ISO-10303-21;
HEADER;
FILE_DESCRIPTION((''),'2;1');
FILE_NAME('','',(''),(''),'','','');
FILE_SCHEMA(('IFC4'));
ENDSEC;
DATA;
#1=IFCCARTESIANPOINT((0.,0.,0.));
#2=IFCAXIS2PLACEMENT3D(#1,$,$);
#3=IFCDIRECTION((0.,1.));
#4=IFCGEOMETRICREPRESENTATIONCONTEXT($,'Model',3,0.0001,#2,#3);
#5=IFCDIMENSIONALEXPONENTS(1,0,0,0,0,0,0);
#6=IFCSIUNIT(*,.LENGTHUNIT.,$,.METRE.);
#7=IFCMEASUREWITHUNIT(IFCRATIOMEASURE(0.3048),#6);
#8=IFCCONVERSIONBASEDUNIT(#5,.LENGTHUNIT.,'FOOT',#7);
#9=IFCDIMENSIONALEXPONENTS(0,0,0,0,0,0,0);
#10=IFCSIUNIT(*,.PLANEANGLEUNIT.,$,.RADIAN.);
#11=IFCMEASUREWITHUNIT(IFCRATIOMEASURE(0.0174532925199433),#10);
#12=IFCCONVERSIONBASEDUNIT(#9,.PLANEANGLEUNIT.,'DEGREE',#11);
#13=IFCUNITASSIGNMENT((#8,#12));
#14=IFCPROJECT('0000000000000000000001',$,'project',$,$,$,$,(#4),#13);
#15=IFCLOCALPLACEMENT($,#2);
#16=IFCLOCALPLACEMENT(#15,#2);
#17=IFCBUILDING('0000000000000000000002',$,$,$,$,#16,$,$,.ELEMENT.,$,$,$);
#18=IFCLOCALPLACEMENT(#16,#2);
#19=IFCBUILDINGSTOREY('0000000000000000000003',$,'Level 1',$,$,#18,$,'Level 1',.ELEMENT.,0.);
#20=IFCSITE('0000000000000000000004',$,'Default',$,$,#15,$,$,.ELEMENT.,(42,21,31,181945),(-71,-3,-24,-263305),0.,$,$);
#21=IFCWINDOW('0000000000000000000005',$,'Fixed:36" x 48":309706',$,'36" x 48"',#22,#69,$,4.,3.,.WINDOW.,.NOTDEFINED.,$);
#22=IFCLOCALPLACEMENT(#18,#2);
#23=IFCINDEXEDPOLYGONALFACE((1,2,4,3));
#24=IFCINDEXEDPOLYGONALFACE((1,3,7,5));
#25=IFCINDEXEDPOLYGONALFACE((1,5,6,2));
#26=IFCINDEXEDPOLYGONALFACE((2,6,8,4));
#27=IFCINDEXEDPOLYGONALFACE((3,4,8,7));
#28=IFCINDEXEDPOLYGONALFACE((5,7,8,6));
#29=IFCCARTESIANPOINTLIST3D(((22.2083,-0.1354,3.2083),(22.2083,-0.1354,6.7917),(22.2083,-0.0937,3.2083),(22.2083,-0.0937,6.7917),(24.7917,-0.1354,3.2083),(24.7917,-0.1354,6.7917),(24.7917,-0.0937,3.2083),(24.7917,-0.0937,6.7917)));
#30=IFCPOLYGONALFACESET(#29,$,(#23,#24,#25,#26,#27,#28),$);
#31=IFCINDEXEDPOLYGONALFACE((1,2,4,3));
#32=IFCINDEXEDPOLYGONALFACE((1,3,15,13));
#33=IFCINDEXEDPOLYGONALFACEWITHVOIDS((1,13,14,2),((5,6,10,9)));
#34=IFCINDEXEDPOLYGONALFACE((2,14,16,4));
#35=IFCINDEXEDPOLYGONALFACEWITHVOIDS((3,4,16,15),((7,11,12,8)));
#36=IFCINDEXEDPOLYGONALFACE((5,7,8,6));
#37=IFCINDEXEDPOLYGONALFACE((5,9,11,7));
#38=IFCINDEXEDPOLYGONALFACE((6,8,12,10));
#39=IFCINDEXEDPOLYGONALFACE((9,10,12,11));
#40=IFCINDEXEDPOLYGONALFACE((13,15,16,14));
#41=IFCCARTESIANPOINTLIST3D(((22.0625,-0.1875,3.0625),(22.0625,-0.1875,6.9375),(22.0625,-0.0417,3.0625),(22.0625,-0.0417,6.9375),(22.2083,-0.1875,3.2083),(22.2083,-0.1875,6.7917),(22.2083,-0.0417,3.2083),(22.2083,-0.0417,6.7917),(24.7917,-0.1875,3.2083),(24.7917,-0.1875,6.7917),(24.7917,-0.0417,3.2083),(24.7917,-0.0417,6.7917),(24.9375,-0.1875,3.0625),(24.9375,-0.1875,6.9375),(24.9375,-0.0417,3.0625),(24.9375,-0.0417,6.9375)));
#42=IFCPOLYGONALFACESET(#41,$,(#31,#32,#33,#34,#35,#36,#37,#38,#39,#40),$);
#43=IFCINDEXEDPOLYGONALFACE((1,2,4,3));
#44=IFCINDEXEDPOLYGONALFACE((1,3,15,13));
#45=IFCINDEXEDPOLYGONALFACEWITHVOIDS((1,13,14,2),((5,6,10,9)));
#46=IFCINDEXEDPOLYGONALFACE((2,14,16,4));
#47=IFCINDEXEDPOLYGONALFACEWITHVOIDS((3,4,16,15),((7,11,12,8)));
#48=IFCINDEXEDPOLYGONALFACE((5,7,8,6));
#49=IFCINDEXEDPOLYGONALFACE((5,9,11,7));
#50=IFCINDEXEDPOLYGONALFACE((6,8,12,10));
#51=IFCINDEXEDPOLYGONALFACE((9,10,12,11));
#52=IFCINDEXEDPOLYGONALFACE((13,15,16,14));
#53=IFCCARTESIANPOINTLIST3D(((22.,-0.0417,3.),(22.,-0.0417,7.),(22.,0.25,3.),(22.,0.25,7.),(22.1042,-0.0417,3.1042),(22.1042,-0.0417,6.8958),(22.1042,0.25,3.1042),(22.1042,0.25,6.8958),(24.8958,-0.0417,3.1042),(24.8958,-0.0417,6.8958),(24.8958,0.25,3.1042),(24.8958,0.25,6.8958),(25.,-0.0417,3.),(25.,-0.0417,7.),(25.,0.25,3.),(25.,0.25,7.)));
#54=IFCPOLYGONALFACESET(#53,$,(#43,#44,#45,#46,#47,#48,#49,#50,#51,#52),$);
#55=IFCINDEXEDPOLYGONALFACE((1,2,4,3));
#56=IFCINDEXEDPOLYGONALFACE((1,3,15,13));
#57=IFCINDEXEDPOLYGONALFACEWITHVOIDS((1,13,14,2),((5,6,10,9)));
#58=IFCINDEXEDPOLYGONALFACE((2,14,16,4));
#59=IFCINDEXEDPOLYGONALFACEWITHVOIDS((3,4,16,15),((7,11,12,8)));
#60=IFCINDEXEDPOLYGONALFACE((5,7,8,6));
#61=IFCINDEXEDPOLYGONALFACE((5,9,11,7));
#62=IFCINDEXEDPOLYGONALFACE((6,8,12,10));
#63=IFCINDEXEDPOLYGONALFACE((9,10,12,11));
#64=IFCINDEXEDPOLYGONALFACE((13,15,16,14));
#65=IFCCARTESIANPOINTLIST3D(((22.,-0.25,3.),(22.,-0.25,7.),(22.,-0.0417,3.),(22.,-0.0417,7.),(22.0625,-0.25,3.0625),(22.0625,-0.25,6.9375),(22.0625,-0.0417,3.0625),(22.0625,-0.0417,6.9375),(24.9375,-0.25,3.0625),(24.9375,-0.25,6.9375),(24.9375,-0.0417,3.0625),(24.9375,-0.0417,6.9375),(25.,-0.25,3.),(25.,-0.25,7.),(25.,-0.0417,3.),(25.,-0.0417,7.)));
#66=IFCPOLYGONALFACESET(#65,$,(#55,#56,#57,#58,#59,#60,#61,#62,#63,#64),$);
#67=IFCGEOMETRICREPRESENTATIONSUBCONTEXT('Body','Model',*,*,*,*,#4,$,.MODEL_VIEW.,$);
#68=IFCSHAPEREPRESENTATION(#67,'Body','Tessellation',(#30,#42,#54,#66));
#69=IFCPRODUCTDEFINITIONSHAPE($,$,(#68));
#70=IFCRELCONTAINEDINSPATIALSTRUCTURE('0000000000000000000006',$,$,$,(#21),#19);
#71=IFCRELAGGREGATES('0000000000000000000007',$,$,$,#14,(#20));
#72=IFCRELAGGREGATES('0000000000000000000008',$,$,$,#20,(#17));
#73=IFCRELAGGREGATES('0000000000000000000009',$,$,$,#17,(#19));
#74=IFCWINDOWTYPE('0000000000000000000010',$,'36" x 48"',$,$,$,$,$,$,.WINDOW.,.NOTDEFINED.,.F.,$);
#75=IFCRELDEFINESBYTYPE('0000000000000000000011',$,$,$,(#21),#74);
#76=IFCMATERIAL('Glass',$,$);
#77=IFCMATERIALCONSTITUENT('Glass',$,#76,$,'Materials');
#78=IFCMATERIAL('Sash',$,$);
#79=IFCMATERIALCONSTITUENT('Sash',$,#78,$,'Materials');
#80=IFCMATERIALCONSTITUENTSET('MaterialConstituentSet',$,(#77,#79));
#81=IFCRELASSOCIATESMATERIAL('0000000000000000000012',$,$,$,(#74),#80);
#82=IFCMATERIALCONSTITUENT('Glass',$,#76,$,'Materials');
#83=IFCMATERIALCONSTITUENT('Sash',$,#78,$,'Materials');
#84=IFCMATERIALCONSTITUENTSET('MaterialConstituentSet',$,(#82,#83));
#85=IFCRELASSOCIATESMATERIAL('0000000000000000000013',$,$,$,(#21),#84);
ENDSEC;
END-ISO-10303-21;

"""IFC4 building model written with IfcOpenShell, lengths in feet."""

from ifc_helpers import new_model, entity, si_unit, converted_unit, direction, frame, frame_2d, origin, place, context, subcontext, project, spatial, polyline, rectangle, outline, extrude, source, transform, mapped, material, constituent, constituent_set, type_object, type_shapes, element, save


model = new_model("IFC4")

# Units and contexts
model_context = context("Model", 3, precision=0.0001, world=origin(), true_north=direction((0.0, 1.0)))
body_context = subcontext(model_context, "Body", "Model", "MODEL_VIEW")
ifc_project = project(units=[converted_unit("LENGTHUNIT", "FOOT", entity("IfcRatioMeasure", 0.3048), si_unit("LENGTHUNIT", "METRE"), dimensions=[1, 0, 0, 0, 0, 0, 0]), converted_unit("PLANEANGLEUNIT", "DEGREE", entity("IfcRatioMeasure", 0.0174532925199433), si_unit("PLANEANGLEUNIT", "RADIAN"), dimensions=[0, 0, 0, 0, 0, 0, 0])], contexts=[model_context])

# Site, building, storey
site_placement = place(None, origin())
site = spatial("IfcSite", under=ifc_project, at=site_placement, Name="Default", CompositionType="ELEMENT", RefLatitude=(42, 21, 31, 181945), RefLongitude=(-71, -3, -24, -263305), RefElevation=0.0)
building_placement = place(site_placement, origin())
building = spatial("IfcBuilding", under=site, at=building_placement, CompositionType="ELEMENT")
storey_placement = place(building_placement, origin())
storey = spatial("IfcBuildingStorey", under=building, at=storey_placement, Name="Level 1", LongName="Level 1", CompositionType="ELEMENT", Elevation=0.0)

# Window
ifc_material_1 = material(Name="Glass")
ifc_constituent_1 = constituent(ifc_material_1, Name="Glass", Category="Materials")
ifc_material_2 = material(Name="Sash")
ifc_constituent_2 = constituent(ifc_material_2, Name="Sash", Category="Materials")
ifc_constituent_set_1 = constituent_set(constituents=[ifc_constituent_1, ifc_constituent_2], Name="MaterialConstituentSet")
ifc_constituent_3 = constituent(ifc_material_1, Name="Glass", Category="Materials")
ifc_constituent_4 = constituent(ifc_material_2, Name="Sash", Category="Materials")
ifc_constituent_set_2 = constituent_set(constituents=[ifc_constituent_3, ifc_constituent_4], Name="MaterialConstituentSet")
window_type = type_object("IfcWindowType", Name="36\" x 48\"", ParameterTakesPrecedence=False, PartitioningType="NOTDEFINED", PredefinedType="WINDOW", material=ifc_constituent_set_2)
shared_shape = source(origin(), body_context, "Body", "SweptSolid", [
    extrude(rectangle(XDim=0.0417, YDim=2.5833, at=frame_2d((0.0, 0.0), x_axis=(1.0, 0.0))), frame((1.5, 0.3646, 0.2083), z_axis=(0.0, 0.0, 1.0), x_axis=(0.0, 1.0, 0.0)), (0.0, 0.0, 1.0), 3.5833),
    extrude(outline(polyline([(-1.4375, -1.9375), (1.4375, -1.9375), (1.4375, 1.9375), (-1.4375, 1.9375), (-1.4375, -1.9375)]), holes=[polyline([(-1.2917, -1.7917), (-1.2917, 1.7917), (1.2917, 1.7917), (1.2917, -1.7917), (-1.2917, -1.7917)])]), frame((1.5, 0.2917, 2.0), z_axis=(0.0, 1.0, 0.0), x_axis=(1.0, 0.0, 0.0)), (0.0, 0.0, 1.0), 0.1458),
    extrude(outline(polyline([(-1.5, -2.0), (1.5, -2.0), (1.5, 2.0), (-1.5, 2.0), (-1.5, -2.0)]), holes=[polyline([(-1.3958, -1.8958), (-1.3958, 1.8958), (1.3958, 1.8958), (1.3958, -1.8958), (-1.3958, -1.8958)])]), frame((1.5, 0.0, 2.0), z_axis=(0.0, 1.0, 0.0), x_axis=(1.0, 0.0, 0.0)), (0.0, 0.0, 1.0), 0.2917),
    extrude(outline(polyline([(-2.0, -1.5), (2.0, -1.5), (2.0, 1.5), (-2.0, 1.5), (-2.0, -1.5)]), holes=[polyline([(-1.9375, -1.4375), (-1.9375, 1.4375), (1.9375, 1.4375), (1.9375, -1.4375), (-1.9375, -1.4375)])]), frame((1.5, 0.2917, 2.0), z_axis=(0.0, 1.0, 0.0), x_axis=(0.0, 0.0, -1.0)), (0.0, 0.0, 1.0), 0.2083),
])
type_shapes(window_type, [shared_shape])
placement_1 = place(storey_placement, frame((46.25, 0.0, 0.0), z_axis=(0.0, 0.0, 1.0), x_axis=(-1.0, 0.0, 0.0)))
placement_2 = place(placement_1, frame((21.25, -0.25, 3.0)))
window_placement = place(placement_2, origin())
element("IfcWindow", 1, at=window_placement, inside=storey, type_object=window_type, material=ifc_constituent_set_1, Name="Fixed:36\" x 48\":309706", ObjectType="36\" x 48\"", OverallHeight=4.0, OverallWidth=3.0, PartitioningType="NOTDEFINED", PredefinedType="WINDOW", context=body_context, shape_type="MappedRepresentation", body=[
    mapped(shared_shape, transform((0.0, 0.0, 0.0), scale=1.0)),
])

save(model, "model.ifc")
